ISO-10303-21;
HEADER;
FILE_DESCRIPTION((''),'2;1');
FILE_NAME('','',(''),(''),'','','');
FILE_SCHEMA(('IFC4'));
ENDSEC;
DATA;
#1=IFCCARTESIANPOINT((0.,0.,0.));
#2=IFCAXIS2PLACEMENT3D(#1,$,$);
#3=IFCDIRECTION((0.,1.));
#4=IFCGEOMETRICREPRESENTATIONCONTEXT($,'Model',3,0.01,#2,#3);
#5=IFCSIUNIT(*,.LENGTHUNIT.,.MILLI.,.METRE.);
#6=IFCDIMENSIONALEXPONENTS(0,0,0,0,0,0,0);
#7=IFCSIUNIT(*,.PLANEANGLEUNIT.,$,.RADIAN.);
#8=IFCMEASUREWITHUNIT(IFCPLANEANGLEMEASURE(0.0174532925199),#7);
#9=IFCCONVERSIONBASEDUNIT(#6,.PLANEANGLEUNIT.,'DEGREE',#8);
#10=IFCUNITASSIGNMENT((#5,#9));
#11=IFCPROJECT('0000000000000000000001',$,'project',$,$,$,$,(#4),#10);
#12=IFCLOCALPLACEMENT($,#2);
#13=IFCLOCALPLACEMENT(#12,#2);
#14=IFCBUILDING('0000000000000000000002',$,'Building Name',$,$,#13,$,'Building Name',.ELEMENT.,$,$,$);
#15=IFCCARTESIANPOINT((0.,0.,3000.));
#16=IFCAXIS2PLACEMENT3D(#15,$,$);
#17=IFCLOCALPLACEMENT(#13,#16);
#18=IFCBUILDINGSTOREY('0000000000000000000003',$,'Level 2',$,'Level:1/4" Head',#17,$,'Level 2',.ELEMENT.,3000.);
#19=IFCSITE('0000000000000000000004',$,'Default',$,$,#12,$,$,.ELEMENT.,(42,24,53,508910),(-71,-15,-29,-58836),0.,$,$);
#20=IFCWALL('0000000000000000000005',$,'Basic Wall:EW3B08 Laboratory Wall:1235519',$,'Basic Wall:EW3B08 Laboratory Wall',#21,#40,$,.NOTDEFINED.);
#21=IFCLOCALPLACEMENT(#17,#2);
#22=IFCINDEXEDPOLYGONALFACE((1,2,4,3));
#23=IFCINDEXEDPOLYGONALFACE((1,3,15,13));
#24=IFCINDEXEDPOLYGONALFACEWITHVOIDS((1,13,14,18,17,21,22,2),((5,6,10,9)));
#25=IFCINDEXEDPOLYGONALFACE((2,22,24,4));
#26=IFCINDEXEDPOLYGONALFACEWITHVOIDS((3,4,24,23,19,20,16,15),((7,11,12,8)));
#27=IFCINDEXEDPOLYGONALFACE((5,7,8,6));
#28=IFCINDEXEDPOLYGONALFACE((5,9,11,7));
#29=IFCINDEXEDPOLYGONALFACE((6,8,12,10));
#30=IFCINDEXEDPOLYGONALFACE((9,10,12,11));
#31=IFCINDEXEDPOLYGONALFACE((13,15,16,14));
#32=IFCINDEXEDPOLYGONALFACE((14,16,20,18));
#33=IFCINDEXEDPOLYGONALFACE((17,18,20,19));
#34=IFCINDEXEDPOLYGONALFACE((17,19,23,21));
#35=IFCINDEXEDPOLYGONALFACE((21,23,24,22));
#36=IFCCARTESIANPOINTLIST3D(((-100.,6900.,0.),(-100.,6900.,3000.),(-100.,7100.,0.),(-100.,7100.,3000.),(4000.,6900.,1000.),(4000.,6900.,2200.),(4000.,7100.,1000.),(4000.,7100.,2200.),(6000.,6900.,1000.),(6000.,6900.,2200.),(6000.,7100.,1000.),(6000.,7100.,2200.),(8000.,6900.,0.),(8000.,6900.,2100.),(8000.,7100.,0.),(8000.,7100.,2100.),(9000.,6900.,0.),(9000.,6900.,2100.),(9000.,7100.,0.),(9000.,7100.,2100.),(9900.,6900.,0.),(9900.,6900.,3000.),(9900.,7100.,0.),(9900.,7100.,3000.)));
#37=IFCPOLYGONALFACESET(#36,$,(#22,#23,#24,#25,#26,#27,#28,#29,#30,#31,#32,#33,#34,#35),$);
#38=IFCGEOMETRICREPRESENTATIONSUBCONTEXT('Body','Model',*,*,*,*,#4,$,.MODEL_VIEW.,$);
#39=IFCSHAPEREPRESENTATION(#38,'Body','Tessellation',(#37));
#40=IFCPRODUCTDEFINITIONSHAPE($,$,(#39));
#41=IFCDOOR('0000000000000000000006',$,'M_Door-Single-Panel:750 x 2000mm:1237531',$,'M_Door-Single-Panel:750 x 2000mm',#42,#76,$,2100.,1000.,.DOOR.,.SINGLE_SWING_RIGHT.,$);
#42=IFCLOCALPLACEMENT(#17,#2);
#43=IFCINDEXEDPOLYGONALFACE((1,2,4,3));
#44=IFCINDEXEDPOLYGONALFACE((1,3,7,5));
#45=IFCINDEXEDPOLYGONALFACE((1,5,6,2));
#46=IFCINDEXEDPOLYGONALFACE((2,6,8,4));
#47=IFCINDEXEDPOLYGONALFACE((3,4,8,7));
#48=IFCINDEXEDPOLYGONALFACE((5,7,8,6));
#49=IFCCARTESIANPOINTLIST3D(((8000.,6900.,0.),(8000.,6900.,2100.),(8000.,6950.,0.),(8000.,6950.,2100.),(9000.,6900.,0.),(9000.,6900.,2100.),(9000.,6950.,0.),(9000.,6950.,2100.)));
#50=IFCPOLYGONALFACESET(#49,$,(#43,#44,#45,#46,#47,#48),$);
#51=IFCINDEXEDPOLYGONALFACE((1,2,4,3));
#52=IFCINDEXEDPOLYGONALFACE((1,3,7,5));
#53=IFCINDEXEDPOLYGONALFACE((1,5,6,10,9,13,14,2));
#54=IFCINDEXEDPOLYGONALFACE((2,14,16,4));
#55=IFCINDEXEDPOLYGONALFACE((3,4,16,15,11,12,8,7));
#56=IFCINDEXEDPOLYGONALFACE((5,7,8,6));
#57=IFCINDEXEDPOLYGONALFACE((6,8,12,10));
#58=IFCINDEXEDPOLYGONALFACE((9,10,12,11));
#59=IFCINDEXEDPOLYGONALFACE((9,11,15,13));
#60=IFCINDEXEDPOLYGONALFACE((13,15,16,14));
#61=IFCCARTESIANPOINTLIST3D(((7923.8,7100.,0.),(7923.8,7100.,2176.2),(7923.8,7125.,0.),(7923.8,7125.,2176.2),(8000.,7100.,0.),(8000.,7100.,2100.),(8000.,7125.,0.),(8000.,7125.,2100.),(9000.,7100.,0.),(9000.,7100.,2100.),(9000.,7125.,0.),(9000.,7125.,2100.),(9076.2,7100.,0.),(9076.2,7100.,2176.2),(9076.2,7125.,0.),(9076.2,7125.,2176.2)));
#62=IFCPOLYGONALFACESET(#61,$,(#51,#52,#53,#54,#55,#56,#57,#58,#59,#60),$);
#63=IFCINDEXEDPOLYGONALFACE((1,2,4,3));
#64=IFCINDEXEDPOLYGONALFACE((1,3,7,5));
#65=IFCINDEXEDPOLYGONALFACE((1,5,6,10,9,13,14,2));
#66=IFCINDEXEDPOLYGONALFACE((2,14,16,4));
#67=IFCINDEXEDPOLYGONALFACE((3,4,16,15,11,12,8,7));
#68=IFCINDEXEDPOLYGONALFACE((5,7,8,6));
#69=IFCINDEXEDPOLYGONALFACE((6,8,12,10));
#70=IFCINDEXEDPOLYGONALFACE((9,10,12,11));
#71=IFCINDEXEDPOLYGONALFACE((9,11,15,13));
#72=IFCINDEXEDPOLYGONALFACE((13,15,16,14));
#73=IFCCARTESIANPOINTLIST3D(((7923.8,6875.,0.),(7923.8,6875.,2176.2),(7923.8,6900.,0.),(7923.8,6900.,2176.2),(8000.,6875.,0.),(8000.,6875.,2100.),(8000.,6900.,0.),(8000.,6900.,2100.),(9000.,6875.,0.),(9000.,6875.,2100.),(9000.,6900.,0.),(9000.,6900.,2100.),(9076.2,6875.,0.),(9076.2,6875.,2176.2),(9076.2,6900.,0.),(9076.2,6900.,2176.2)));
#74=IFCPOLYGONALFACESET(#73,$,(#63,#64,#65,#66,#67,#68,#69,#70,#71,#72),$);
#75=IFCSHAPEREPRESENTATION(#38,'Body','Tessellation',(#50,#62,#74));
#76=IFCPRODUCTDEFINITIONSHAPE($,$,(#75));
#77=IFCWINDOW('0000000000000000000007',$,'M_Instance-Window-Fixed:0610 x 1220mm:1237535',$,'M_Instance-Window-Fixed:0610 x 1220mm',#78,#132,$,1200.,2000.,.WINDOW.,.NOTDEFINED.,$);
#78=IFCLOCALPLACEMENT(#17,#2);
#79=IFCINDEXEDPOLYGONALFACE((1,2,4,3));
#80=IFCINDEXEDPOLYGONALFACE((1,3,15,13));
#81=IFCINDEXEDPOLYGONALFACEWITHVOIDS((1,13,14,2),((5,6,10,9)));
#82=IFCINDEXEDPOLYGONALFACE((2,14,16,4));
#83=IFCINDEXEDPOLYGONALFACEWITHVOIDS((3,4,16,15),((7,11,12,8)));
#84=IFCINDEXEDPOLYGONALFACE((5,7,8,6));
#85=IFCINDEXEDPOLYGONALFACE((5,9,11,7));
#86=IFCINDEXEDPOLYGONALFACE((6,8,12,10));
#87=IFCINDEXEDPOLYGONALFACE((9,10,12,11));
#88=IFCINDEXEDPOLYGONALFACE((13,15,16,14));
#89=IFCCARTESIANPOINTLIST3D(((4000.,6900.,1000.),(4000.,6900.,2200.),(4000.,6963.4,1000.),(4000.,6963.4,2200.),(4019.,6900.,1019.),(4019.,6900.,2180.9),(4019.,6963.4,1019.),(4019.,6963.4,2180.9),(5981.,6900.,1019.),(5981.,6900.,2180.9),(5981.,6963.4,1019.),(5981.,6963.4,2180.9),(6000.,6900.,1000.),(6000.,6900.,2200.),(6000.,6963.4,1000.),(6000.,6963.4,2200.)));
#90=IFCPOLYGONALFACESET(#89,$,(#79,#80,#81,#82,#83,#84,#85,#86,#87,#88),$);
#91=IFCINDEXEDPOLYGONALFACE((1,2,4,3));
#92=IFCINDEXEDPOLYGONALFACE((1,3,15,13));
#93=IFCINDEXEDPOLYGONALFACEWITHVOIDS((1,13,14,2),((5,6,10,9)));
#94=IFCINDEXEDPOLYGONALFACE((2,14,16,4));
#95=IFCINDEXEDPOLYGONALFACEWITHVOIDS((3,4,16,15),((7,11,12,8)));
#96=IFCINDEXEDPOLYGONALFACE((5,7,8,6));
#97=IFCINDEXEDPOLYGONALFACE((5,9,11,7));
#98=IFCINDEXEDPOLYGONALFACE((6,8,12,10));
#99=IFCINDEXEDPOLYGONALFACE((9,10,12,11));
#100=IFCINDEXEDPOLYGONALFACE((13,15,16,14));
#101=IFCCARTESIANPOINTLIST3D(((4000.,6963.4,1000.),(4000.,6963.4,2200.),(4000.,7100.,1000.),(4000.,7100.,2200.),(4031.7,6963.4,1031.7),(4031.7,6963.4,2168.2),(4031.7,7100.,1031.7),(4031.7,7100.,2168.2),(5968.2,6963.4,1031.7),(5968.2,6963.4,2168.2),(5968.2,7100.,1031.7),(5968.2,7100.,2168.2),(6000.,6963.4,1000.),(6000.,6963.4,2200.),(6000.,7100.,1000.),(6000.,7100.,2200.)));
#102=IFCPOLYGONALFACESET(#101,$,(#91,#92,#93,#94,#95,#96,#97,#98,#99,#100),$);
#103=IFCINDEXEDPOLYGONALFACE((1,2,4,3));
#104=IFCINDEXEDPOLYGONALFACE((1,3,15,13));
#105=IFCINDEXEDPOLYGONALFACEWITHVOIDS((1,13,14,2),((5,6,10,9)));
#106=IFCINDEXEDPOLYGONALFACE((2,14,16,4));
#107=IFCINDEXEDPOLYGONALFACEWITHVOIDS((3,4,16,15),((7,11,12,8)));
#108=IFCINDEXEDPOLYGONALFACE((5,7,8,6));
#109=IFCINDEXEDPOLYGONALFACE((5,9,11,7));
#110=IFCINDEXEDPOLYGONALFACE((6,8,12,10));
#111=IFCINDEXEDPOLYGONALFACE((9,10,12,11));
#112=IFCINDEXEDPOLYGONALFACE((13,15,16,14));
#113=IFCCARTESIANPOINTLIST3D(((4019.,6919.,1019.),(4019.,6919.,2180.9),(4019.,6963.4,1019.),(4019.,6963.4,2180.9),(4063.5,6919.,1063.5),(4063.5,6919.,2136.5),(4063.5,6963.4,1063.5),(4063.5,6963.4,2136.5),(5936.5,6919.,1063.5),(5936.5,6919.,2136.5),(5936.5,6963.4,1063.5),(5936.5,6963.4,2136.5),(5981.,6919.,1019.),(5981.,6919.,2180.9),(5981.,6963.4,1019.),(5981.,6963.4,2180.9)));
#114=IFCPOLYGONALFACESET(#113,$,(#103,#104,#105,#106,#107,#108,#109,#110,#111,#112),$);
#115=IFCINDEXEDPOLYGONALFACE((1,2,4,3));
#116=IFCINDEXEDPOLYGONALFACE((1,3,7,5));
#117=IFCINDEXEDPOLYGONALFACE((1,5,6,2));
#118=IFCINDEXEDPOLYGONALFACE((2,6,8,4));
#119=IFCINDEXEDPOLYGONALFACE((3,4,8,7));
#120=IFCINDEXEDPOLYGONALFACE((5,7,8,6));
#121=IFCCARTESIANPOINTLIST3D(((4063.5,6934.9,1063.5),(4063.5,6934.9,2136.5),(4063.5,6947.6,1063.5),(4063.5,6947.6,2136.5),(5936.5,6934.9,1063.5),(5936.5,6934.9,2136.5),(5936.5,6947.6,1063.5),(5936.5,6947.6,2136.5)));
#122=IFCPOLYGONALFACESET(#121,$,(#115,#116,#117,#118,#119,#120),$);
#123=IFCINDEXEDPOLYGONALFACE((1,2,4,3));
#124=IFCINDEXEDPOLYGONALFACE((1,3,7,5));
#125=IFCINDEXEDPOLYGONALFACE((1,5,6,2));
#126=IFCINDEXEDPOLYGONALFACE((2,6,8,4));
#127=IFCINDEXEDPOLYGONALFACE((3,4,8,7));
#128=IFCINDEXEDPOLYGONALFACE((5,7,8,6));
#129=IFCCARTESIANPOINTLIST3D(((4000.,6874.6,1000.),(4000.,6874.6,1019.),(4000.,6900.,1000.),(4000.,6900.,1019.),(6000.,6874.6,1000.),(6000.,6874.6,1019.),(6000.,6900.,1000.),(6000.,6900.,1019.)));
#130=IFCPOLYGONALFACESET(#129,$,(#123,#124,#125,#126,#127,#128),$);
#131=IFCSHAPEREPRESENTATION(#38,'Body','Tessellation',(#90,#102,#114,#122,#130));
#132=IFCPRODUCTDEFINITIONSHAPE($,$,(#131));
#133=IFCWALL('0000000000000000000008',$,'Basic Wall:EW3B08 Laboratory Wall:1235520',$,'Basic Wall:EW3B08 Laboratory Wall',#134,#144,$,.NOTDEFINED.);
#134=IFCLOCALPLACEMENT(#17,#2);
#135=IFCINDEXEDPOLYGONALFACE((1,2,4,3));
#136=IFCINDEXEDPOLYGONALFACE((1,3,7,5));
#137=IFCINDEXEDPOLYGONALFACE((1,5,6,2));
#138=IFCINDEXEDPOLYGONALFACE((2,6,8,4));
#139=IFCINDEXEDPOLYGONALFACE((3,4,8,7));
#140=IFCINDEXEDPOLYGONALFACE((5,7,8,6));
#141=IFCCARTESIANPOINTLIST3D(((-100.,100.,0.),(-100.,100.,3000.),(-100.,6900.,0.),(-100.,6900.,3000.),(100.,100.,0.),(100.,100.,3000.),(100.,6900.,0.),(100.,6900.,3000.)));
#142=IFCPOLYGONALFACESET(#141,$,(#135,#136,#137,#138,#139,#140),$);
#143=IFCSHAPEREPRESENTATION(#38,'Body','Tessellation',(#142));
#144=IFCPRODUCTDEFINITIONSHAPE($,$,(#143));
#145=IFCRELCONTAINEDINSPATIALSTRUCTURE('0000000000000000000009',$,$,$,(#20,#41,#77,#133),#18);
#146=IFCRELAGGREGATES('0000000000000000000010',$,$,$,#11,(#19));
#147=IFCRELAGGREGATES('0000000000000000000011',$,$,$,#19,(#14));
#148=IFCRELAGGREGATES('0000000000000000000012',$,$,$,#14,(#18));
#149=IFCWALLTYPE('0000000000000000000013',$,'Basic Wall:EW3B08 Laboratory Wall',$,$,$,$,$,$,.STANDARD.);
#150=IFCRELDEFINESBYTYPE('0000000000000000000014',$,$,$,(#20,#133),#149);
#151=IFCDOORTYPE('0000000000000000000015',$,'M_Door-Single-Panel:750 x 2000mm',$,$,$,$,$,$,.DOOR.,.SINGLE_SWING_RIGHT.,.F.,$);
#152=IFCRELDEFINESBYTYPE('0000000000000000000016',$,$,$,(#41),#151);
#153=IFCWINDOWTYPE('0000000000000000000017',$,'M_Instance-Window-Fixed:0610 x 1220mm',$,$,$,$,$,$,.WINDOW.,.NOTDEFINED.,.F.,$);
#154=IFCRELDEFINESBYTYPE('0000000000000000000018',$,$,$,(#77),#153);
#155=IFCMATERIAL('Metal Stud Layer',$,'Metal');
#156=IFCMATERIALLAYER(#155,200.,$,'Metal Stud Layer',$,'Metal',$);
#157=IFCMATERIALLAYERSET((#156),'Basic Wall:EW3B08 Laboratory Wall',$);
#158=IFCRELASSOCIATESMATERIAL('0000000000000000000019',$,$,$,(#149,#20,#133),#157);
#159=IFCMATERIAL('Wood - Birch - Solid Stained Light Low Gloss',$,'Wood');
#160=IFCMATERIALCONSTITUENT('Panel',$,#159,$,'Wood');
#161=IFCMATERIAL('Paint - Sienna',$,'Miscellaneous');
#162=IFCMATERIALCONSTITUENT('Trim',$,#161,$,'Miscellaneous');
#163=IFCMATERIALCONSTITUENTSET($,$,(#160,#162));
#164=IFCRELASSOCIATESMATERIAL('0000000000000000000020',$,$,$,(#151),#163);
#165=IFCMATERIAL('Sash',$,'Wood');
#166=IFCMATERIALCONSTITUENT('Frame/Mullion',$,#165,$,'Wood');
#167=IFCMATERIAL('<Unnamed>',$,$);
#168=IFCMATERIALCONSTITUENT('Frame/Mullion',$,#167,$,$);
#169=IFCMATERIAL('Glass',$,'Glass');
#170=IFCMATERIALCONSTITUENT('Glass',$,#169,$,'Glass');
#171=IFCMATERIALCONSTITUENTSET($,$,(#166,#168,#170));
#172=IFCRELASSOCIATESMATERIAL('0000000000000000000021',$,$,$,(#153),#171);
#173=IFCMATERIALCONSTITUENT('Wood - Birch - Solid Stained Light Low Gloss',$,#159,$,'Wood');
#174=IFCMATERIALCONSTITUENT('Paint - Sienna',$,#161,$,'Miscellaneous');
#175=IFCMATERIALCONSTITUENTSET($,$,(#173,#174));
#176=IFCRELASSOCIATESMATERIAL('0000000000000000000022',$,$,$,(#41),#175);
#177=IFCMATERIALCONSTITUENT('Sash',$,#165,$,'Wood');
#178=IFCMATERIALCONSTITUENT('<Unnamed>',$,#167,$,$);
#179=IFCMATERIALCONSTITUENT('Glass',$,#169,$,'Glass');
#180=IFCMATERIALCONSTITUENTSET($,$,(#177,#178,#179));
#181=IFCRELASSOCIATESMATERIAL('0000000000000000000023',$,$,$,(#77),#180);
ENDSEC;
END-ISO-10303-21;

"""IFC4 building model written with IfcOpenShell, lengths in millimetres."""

from ifc_helpers import new_model, entity, si_unit, converted_unit, direction, frame, frame_2d, origin, place, context, subcontext, project, spatial, polyline, rectangle, outline, extrude, source, transform, mapped, material, layer, layer_set, layer_usage, constituent, constituent_set, type_object, type_shapes, element, fill, save


model = new_model("IFC4")

# Units and contexts
model_context = context("Model", 3, precision=0.01, world=origin(), true_north=direction((0.0, 1.0)))
body_context = subcontext(model_context, "Body", "Model", "MODEL_VIEW")
ifc_project = project(units=[si_unit("LENGTHUNIT", "METRE", prefix="MILLI"), converted_unit("PLANEANGLEUNIT", "DEGREE", entity("IfcPlaneAngleMeasure", 0.0174532925199), si_unit("PLANEANGLEUNIT", "RADIAN"), dimensions=[0, 0, 0, 0, 0, 0, 0])], contexts=[model_context])

# Site, building, storey
site_placement = place(None, origin())
site = spatial("IfcSite", under=ifc_project, at=site_placement, Name="Default", CompositionType="ELEMENT", RefLatitude=(42, 24, 53, 508910), RefLongitude=(-71, -15, -29, -58836), RefElevation=0.0)
building_placement = place(site_placement, origin())
building = spatial("IfcBuilding", under=site, at=building_placement, Name="Building Name", LongName="Building Name", CompositionType="ELEMENT")
storey_placement = place(building_placement, frame((0.0, 0.0, 3000.0)))
storey = spatial("IfcBuildingStorey", under=building, at=storey_placement, Name="Level 2", ObjectType="Level:1/4\" Head", LongName="Level 2", CompositionType="ELEMENT", Elevation=3000.0)

# Shared definitions
ifc_material_1 = material(Name="Metal Stud Layer", Category="Metal")
ifc_layer_1 = layer(ifc_material_1, 200.0, Name="Metal Stud Layer", Category="Metal")
ifc_layer_set_1 = layer_set([ifc_layer_1], Name="Basic Wall:EW3B08 Laboratory Wall")
wall_type = type_object("IfcWallType", Name="Basic Wall:EW3B08 Laboratory Wall", PredefinedType="STANDARD", material=ifc_layer_set_1)
ifc_material_2 = material(Name="Wood - Birch - Solid Stained Light Low Gloss", Category="Wood")
ifc_material_3 = material(Name="Paint - Sienna", Category="Miscellaneous")
ifc_constituent_1 = constituent(ifc_material_2, Name="Panel", Category="Wood")
ifc_constituent_2 = constituent(ifc_material_3, Name="Trim", Category="Miscellaneous")
ifc_constituent_set_1 = constituent_set(constituents=[ifc_constituent_1, ifc_constituent_2])
door_type = type_object("IfcDoorType", Name="M_Door-Single-Panel:750 x 2000mm", OperationType="SINGLE_SWING_RIGHT", ParameterTakesPrecedence=False, PredefinedType="DOOR", material=ifc_constituent_set_1)
shared_shape_1 = source(origin(), body_context, "Body", "SweptSolid", [
    extrude(rectangle(XDim=50.0, YDim=1000.0, at=frame_2d((0.0, 0.0), x_axis=(1.0, 0.0))), frame((500.0, 175.0, 0.0), z_axis=(0.0, 0.0, 1.0), x_axis=(0.0, 1.0, 0.0)), (0.0, 0.0, 1.0), 2100.0),
    extrude(outline(polyline([(-1107.2, -576.2), (1069.0, -576.2), (1069.0, -500.0), (-1031.0, -500.0), (-1031.0, 500.0), (1069.0, 500.0), (1069.0, 576.2), (-1107.2, 576.2), (-1107.2, -576.2)])), frame((500.0, -25.0, 1069.0), z_axis=(0.0, 1.0, 0.0), x_axis=(0.0, 0.0, -1.0)), (0.0, 0.0, 1.0), 25.0),
    extrude(outline(polyline([(-576.2, -1107.2), (576.2, -1107.2), (576.2, 1069.0), (500.0, 1069.0), (500.0, -1031.0), (-500.0, -1031.0), (-500.0, 1069.0), (-576.2, 1069.0), (-576.2, -1107.2)])), frame((500.0, 200.0, 1069.0), z_axis=(0.0, 1.0, 0.0), x_axis=(1.0, 0.0, 0.0)), (0.0, 0.0, 1.0), 25.0),
])
type_shapes(door_type, [shared_shape_1])
ifc_material_4 = material(Name="Sash", Category="Wood")
ifc_material_5 = material(Name="<Unnamed>")
ifc_material_6 = material(Name="Glass", Category="Glass")
ifc_constituent_3 = constituent(ifc_material_4, Name="Frame/Mullion", Category="Wood")
ifc_constituent_4 = constituent(ifc_material_5, Name="Frame/Mullion")
ifc_constituent_5 = constituent(ifc_material_6, Name="Glass", Category="Glass")
ifc_constituent_set_2 = constituent_set(constituents=[ifc_constituent_3, ifc_constituent_4, ifc_constituent_5])
window_type = type_object("IfcWindowType", Name="M_Instance-Window-Fixed:0610 x 1220mm", ParameterTakesPrecedence=False, PartitioningType="NOTDEFINED", PredefinedType="WINDOW", material=ifc_constituent_set_2)
shared_shape_2 = source(origin(), body_context, "Body", "SweptSolid", [
    extrude(outline(polyline([(-600.0, -1000.0), (600.0, -1000.0), (600.0, 1000.0), (-600.0, 1000.0), (-600.0, -1000.0)]), holes=[polyline([(-581.0, -981.0), (-581.0, 981.0), (581.0, 981.0), (581.0, -981.0), (-581.0, -981.0)])]), frame((1000.0, 136.6, 600.0), z_axis=(0.0, 1.0, 0.0), x_axis=(0.0, 0.0, -1.0)), (0.0, 0.0, 1.0), 63.5),
    extrude(outline(polyline([(-1000.0, -600.0), (1000.0, -600.0), (1000.0, 600.0), (-1000.0, 600.0), (-1000.0, -600.0)]), holes=[polyline([(-968.2, -568.2), (-968.2, 568.2), (968.2, 568.2), (968.2, -568.2), (-968.2, -568.2)])]), frame((1000.0, 0.0, 600.0), z_axis=(0.0, 1.0, 0.0), x_axis=(1.0, 0.0, 0.0)), (0.0, 0.0, 1.0), 136.6),
    extrude(outline(polyline([(-981.0, -581.0), (981.0, -581.0), (981.0, 581.0), (-981.0, 581.0), (-981.0, -581.0)]), holes=[polyline([(-936.5, -536.5), (-936.5, 536.5), (936.5, 536.5), (936.5, -536.5), (-936.5, -536.5)])]), frame((1000.0, 136.6, 600.0), z_axis=(0.0, 1.0, 0.0), x_axis=(1.0, 0.0, 0.0)), (0.0, 0.0, 1.0), 44.5),
    extrude(rectangle(XDim=12.7, YDim=1873.0, at=frame_2d((0.0, 0.0), x_axis=(1.0, 0.0))), frame((1000.0, 158.8, 63.5), z_axis=(0.0, 0.0, 1.0), x_axis=(0.0, 1.0, 0.0)), (0.0, 0.0, 1.0), 1073.0),
    extrude(rectangle(XDim=25.4, YDim=2000.0, at=frame_2d((0.0, 0.0), x_axis=(1.0, 0.0))), frame((1000.0, 212.7, 0.0), z_axis=(0.0, 0.0, 1.0), x_axis=(0.0, -1.0, 0.0)), (0.0, 0.0, 1.0), 19.1),
])
type_shapes(window_type, [shared_shape_2])

# Wall, openings, door, window
ifc_layer_usage_1 = layer_usage(ifc_layer_set_1, "AXIS2", "NEGATIVE", 100.0)
wall_1_placement = place(storey_placement, frame((9900.0, 7000.0, 0.0), z_axis=(0.0, 0.0, 1.0), x_axis=(-1.0, 0.0, 0.0)))
wall_1 = element("IfcWall", 1, at=wall_1_placement, inside=storey, type_object=wall_type, material=ifc_layer_usage_1, Name="Basic Wall:EW3B08 Laboratory Wall:1235519", ObjectType="Basic Wall:EW3B08 Laboratory Wall", PredefinedType="NOTDEFINED", context=body_context, shape_type="SweptSolid", body=[
    extrude(rectangle(XDim=10000.0, YDim=200.0, at=frame_2d((5000.0, 0.0), x_axis=(1.0, 0.0))), origin(), (0.0, 0.0, 1.0), 3000.0),
])
opening_1_placement = place(wall_1_placement, frame((900.0, -100.0, 0.0)))
opening_1 = element("IfcOpeningElement", 2, at=opening_1_placement, cuts=wall_1, PredefinedType="OPENING", context=body_context, shape_type="SweptSolid", body=[
    extrude(rectangle(XDim=1000.0, YDim=2100.0, at=frame_2d((1050.0, 500.0), x_axis=(0.0, 1.0))), frame((0.0, 0.0, 0.0), z_axis=(0.0, 1.0, 0.0), x_axis=(0.0, 0.0, 1.0)), (0.0, 0.0, 1.0), 200.0),
])
opening_2_placement = place(wall_1_placement, frame((3900.0, -100.0, 1000.0)))
opening_2 = element("IfcOpeningElement", 3, at=opening_2_placement, cuts=wall_1, PredefinedType="OPENING", context=body_context, shape_type="SweptSolid", body=[
    extrude(rectangle(XDim=1200.0, YDim=2000.0, at=frame_2d((600.0, 1000.0), x_axis=(-1.0, 0.0))), frame((0.0, 0.0, 0.0), z_axis=(0.0, 1.0, 0.0), x_axis=(0.0, 0.0, 1.0)), (0.0, 0.0, 1.0), 200.0),
])
ifc_constituent_6 = constituent(ifc_material_2, Name="Wood - Birch - Solid Stained Light Low Gloss", Category="Wood")
ifc_constituent_7 = constituent(ifc_material_3, Name="Paint - Sienna", Category="Miscellaneous")
ifc_constituent_set_3 = constituent_set(constituents=[ifc_constituent_6, ifc_constituent_7])
door_1_placement = place(opening_1_placement, origin())
door_1 = element("IfcDoor", 4, at=door_1_placement, inside=storey, type_object=door_type, material=ifc_constituent_set_3, Name="M_Door-Single-Panel:750 x 2000mm:1237531", ObjectType="M_Door-Single-Panel:750 x 2000mm", OperationType="SINGLE_SWING_RIGHT", OverallHeight=2100.0, OverallWidth=1000.0, PredefinedType="DOOR", context=body_context, shape_type="MappedRepresentation", body=[
    mapped(shared_shape_1, transform((0.0, 0.0, 0.0), scale=1.0)),
])
fill(opening_1, door_1)
ifc_constituent_8 = constituent(ifc_material_4, Name="Sash", Category="Wood")
ifc_constituent_9 = constituent(ifc_material_5, Name="<Unnamed>")
ifc_constituent_10 = constituent(ifc_material_6, Name="Glass", Category="Glass")
ifc_constituent_set_4 = constituent_set(constituents=[ifc_constituent_8, ifc_constituent_9, ifc_constituent_10])
window_1_placement = place(opening_2_placement, origin())
window_1 = element("IfcWindow", 5, at=window_1_placement, inside=storey, type_object=window_type, material=ifc_constituent_set_4, Name="M_Instance-Window-Fixed:0610 x 1220mm:1237535", ObjectType="M_Instance-Window-Fixed:0610 x 1220mm", OverallHeight=1200.0, OverallWidth=2000.0, PartitioningType="NOTDEFINED", PredefinedType="WINDOW", context=body_context, shape_type="MappedRepresentation", body=[
    mapped(shared_shape_2, transform((0.0, 0.0, 0.0), scale=1.0)),
])
fill(opening_2, window_1)

# Wall
ifc_layer_usage_2 = layer_usage(ifc_layer_set_1, "AXIS2", "NEGATIVE", 100.0)
wall_2_placement = place(storey_placement, frame((0.0, 6900.0, 0.0), z_axis=(0.0, 0.0, 1.0), x_axis=(0.0, -1.0, 0.0)))
element("IfcWall", 6, at=wall_2_placement, inside=storey, type_object=wall_type, material=ifc_layer_usage_2, Name="Basic Wall:EW3B08 Laboratory Wall:1235520", ObjectType="Basic Wall:EW3B08 Laboratory Wall", PredefinedType="NOTDEFINED", context=body_context, shape_type="SweptSolid", body=[
    extrude(rectangle(XDim=6800.0, YDim=200.0, at=frame_2d((3400.0, 0.0), x_axis=(-1.0, 0.0))), origin(), (0.0, 0.0, 1.0), 3000.0),
])

save(model, "model.ifc")
